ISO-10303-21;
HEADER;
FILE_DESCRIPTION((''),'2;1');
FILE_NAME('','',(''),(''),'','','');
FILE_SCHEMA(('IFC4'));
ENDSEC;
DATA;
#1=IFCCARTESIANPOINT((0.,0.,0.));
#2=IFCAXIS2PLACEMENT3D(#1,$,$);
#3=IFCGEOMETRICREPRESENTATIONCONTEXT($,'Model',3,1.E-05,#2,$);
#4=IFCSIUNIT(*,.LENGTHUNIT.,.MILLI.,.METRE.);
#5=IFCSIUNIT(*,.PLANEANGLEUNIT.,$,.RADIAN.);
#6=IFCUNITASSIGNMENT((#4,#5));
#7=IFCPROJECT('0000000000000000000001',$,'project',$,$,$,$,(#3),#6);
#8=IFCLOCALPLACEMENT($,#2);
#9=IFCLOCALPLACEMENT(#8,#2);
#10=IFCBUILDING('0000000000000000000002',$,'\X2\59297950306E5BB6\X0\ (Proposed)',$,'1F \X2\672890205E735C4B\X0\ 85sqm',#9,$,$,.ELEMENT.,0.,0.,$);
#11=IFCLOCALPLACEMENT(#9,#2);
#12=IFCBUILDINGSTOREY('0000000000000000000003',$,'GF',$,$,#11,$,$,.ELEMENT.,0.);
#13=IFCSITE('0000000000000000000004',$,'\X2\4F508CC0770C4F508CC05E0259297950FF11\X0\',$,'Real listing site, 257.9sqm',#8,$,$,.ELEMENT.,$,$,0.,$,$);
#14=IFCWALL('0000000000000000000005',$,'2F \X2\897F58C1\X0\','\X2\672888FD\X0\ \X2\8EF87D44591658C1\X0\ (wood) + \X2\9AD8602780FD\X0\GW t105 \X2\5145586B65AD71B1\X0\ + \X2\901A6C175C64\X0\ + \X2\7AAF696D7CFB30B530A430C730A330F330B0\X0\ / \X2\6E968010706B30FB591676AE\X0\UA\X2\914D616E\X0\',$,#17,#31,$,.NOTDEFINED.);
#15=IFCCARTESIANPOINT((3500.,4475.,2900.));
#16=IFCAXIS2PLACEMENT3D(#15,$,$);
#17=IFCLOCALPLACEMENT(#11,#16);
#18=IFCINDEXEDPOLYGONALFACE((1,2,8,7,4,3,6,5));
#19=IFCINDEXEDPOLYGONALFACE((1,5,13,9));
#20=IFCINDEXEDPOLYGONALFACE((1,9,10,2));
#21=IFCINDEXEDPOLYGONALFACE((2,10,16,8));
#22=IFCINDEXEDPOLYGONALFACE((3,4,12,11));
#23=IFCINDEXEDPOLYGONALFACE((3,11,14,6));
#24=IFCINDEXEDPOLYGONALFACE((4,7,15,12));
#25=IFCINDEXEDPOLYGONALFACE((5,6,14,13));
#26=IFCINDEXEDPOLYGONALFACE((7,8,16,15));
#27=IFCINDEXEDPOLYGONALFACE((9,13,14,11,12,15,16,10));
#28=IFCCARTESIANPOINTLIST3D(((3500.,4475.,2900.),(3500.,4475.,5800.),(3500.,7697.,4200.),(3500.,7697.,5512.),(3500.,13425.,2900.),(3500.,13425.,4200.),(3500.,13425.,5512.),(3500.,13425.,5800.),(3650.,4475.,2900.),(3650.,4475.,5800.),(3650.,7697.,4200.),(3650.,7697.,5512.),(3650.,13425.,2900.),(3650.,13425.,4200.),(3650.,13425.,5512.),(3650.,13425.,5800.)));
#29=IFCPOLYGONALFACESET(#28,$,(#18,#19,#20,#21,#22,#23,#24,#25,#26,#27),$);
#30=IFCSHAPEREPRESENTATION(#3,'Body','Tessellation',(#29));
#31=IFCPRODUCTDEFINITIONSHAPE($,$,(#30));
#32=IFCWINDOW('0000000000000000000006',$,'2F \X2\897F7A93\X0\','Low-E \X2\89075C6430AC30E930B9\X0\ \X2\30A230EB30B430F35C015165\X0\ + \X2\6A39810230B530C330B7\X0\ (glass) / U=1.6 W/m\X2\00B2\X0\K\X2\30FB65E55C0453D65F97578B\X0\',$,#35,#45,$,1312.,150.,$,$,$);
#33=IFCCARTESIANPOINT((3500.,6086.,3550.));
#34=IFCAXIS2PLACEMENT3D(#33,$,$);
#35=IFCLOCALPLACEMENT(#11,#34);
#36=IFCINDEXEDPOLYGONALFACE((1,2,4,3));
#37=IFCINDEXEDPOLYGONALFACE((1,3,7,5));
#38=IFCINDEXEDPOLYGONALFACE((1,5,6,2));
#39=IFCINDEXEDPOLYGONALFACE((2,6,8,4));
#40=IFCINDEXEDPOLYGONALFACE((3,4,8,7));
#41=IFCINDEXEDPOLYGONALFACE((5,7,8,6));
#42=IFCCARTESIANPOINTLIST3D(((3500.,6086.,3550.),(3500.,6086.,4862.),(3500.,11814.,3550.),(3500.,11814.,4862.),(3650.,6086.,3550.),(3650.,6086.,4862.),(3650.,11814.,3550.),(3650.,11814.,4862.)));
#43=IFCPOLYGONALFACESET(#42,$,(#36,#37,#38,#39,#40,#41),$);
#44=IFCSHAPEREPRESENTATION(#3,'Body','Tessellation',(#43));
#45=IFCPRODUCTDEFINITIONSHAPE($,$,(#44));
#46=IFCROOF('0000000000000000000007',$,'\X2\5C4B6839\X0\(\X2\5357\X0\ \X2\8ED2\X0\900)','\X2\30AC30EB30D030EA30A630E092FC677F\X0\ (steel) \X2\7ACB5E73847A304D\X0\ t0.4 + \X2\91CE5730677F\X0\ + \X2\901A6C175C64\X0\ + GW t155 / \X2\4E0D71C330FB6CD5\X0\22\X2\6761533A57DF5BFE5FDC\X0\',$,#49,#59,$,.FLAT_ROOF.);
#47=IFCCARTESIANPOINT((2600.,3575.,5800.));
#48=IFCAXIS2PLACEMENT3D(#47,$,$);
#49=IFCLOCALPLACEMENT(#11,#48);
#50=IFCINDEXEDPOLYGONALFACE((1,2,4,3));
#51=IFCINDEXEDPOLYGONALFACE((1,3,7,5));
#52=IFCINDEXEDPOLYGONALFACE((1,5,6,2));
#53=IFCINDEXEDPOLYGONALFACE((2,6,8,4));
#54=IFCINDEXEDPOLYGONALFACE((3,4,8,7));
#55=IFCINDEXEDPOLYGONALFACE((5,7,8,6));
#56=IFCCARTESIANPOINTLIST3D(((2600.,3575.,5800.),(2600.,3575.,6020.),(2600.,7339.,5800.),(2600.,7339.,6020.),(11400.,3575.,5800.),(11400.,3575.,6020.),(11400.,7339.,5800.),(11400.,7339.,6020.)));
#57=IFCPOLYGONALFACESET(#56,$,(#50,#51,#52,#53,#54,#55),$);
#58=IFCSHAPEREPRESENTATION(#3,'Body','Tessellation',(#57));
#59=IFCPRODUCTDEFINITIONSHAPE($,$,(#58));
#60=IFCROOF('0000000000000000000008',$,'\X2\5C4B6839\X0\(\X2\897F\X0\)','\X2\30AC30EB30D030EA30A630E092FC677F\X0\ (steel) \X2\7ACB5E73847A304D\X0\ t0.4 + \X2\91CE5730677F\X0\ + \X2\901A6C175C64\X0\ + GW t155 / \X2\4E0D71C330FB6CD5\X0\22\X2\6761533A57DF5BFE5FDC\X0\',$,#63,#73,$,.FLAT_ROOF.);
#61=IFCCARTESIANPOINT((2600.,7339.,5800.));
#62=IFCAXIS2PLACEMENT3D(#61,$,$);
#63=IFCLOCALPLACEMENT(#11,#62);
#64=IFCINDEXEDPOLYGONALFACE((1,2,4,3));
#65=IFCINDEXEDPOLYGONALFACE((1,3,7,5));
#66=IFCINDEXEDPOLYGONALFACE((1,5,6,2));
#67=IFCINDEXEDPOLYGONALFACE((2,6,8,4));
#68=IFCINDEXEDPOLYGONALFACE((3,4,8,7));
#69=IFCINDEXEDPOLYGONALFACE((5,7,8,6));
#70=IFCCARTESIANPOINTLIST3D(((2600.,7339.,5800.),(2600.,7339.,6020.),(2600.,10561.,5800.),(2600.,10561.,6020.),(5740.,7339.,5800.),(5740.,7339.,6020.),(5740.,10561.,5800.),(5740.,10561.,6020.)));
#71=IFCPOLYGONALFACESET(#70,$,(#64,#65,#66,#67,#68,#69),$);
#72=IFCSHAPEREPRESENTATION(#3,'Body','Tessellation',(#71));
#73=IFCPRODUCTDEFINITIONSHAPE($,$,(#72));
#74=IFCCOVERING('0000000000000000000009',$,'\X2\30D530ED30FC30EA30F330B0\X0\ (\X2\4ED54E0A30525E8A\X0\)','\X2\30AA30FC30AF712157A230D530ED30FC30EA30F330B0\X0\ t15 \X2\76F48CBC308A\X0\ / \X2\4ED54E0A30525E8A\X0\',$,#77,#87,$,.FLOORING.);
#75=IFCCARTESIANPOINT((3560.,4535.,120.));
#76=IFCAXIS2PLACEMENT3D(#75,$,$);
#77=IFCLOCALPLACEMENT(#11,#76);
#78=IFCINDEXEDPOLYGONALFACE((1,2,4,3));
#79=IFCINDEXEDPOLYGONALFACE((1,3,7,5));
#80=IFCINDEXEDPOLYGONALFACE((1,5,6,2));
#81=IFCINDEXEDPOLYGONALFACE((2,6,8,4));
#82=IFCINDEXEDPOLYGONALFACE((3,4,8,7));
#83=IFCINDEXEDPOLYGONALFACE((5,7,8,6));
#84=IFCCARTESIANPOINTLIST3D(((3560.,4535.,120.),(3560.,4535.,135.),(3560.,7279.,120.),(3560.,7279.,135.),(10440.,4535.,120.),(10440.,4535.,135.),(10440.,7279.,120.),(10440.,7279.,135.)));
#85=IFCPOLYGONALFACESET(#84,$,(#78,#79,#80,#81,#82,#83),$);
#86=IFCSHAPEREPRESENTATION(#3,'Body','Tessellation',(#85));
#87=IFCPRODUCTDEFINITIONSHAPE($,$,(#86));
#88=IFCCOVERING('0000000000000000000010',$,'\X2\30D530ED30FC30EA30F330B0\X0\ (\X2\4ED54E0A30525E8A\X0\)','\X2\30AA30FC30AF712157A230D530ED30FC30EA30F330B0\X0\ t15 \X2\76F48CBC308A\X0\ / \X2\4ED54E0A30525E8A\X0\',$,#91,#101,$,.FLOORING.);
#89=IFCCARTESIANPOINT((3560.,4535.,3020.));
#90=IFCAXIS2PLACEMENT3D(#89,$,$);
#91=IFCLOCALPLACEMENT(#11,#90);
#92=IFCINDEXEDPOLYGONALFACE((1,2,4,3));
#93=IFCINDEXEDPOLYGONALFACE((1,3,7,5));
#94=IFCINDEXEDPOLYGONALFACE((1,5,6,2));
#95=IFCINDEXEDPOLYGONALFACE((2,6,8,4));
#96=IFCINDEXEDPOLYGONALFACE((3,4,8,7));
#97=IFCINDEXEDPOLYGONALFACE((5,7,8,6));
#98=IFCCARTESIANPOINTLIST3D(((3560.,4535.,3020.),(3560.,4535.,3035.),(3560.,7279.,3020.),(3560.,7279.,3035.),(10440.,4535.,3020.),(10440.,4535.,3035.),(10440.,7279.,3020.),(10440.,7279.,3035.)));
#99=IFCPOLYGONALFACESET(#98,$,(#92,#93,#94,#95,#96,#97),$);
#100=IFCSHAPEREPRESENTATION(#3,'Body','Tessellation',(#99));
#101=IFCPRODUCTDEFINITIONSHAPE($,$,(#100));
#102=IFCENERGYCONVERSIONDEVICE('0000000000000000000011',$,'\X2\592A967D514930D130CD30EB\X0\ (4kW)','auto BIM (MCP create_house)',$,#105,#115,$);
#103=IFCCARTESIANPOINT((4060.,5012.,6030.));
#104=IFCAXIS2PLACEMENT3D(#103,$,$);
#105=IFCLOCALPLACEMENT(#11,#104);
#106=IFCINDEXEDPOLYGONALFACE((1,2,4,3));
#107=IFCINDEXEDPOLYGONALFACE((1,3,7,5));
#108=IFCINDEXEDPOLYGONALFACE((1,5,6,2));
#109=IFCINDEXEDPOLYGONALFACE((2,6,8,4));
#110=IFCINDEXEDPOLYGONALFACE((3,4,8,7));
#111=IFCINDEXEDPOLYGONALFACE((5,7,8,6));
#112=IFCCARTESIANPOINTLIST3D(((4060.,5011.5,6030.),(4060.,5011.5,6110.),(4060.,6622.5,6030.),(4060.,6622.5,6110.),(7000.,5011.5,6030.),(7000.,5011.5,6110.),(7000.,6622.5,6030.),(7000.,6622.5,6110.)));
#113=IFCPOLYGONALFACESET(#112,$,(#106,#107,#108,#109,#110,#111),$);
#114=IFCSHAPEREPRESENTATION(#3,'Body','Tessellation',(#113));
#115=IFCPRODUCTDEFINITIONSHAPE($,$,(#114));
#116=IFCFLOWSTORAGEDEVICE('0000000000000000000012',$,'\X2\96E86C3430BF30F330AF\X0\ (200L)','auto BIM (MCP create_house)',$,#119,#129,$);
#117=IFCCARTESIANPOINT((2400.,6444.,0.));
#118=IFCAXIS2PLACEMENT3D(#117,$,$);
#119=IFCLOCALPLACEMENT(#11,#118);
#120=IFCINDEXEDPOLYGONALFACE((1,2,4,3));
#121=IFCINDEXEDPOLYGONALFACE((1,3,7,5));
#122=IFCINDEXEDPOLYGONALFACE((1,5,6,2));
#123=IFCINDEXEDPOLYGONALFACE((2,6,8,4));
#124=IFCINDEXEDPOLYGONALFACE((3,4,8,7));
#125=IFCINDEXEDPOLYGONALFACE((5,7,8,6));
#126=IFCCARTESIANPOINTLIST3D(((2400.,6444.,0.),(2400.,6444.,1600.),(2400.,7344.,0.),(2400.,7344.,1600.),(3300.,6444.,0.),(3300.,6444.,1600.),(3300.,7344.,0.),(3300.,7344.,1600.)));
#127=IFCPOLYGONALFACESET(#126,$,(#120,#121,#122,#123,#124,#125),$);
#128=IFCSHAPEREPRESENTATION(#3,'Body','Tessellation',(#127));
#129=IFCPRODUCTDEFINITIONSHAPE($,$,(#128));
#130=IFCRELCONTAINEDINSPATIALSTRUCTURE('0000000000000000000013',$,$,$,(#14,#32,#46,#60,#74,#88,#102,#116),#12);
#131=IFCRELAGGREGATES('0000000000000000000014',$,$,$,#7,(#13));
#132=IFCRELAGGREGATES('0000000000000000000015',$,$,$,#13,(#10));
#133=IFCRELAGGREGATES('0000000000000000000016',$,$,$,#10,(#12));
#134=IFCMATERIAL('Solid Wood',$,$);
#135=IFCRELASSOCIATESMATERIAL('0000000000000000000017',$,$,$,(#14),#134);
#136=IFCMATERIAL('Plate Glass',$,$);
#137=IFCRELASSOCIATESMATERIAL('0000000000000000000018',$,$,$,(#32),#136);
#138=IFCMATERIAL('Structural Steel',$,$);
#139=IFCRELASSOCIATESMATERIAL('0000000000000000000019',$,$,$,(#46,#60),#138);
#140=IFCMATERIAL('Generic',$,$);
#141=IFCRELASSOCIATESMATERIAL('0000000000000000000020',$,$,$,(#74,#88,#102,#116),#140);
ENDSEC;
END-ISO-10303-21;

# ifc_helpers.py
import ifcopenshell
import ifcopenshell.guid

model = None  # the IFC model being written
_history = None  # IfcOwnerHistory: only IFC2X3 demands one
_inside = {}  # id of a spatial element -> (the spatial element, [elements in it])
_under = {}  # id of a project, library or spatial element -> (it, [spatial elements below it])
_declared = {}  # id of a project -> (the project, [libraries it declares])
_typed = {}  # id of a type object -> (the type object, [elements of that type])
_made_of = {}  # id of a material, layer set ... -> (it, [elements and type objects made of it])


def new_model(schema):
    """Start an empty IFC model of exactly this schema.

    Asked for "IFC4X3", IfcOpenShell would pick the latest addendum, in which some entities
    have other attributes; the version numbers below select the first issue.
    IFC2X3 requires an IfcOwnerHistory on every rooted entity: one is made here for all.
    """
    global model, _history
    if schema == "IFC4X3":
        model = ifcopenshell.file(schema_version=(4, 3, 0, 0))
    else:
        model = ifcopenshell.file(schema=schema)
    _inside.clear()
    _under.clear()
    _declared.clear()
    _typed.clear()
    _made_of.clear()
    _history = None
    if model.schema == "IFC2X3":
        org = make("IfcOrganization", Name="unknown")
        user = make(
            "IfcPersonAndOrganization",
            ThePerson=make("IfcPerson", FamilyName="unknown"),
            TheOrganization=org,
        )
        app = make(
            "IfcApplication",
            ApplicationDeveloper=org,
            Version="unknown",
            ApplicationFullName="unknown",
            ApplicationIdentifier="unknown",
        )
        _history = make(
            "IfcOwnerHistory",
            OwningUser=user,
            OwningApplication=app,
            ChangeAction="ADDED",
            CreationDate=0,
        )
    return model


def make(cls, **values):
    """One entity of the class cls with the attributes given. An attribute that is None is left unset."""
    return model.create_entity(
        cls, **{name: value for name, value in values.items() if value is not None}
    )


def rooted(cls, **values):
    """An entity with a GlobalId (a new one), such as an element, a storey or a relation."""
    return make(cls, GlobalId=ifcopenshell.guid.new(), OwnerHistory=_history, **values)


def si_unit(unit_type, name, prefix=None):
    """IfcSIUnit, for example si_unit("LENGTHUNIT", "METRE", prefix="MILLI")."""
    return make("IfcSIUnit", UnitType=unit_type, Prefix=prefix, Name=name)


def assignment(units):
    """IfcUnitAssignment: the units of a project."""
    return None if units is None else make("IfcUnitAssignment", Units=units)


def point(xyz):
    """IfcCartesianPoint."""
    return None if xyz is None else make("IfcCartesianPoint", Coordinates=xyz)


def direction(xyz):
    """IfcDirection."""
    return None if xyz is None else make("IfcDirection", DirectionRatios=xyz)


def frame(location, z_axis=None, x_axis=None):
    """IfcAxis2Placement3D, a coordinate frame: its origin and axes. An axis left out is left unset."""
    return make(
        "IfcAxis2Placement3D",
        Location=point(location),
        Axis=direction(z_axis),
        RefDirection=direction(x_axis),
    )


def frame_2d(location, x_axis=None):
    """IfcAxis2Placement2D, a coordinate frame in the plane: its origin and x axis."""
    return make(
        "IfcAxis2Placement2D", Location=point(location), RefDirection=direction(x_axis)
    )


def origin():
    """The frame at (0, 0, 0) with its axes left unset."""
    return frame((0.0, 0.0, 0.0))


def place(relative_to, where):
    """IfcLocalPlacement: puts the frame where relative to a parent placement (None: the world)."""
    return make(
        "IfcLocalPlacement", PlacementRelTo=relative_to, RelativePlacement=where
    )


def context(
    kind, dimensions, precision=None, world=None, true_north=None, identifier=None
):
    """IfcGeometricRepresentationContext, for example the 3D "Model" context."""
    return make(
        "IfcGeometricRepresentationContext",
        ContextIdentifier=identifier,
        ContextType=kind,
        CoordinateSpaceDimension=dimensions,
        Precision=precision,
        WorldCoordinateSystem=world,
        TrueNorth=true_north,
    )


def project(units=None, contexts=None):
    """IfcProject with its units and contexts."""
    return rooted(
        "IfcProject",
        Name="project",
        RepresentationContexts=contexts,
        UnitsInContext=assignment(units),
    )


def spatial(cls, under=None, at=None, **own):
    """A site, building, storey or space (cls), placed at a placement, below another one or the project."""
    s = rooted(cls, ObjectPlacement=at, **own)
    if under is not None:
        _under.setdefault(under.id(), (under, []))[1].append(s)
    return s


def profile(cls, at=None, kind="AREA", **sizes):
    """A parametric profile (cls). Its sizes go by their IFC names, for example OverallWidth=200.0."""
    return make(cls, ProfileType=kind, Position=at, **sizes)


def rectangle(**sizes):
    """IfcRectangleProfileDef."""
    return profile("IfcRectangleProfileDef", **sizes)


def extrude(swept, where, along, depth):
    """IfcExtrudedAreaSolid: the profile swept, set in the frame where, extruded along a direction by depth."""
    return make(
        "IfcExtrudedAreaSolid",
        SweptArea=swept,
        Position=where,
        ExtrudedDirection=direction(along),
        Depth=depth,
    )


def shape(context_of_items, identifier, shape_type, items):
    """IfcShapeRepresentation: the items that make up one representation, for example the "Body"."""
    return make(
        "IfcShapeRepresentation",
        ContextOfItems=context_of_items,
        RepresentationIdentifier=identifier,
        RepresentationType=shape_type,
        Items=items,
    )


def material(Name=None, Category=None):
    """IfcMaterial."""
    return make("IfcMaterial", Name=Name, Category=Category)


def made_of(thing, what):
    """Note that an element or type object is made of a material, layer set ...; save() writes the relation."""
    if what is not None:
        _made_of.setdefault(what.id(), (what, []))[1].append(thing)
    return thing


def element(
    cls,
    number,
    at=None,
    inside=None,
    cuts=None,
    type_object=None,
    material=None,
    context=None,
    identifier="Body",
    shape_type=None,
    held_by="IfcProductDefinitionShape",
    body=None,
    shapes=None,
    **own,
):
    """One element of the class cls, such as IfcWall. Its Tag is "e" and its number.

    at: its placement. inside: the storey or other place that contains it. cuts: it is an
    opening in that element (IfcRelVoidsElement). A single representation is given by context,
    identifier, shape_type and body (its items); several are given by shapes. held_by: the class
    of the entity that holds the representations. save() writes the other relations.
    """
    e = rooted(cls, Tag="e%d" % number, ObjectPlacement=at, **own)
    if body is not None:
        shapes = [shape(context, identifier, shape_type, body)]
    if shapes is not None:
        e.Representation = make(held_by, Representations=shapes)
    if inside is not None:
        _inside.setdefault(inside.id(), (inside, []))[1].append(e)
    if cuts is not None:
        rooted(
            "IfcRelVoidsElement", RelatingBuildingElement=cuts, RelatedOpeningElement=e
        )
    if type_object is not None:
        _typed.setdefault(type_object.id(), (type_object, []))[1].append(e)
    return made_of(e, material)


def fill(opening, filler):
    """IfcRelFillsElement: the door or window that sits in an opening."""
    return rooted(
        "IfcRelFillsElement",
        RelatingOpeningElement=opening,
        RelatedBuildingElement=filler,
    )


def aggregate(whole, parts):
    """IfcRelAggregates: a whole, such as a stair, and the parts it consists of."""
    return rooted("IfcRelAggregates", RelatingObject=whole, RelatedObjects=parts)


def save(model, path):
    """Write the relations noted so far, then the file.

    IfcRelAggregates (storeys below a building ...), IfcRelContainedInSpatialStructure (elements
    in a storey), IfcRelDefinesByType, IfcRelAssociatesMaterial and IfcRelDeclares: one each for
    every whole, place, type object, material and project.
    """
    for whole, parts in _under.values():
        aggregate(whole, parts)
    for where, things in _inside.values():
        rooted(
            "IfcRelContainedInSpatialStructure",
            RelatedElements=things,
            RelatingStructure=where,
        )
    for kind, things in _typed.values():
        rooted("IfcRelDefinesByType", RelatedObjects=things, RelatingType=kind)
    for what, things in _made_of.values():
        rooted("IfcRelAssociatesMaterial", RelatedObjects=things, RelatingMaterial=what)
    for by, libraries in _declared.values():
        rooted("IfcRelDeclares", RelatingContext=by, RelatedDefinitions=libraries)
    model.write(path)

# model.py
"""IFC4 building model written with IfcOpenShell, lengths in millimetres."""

from ifc_helpers import new_model, si_unit, frame, frame_2d, origin, place, context, project, spatial, rectangle, extrude, material, element, fill, save


model = new_model("IFC4")

# Units and contexts
model_context = context("Model", 3, precision=1e-05, world=origin())
ifc_project = project(units=[si_unit("LENGTHUNIT", "METRE", prefix="MILLI"), si_unit("PLANEANGLEUNIT", "RADIAN")], contexts=[model_context])

# Site, building, storey
site_placement = place(None, origin())
site = spatial("IfcSite", under=ifc_project, at=site_placement, Name="佐賀県佐賀市天祐１", ObjectType="Real listing site, 257.9sqm", CompositionType="ELEMENT", RefElevation=0.0)
building_placement = place(site_placement, origin())
building = spatial("IfcBuilding", under=site, at=building_placement, Name="天祐の家 (Proposed)", ObjectType="1F 木造平屋 85sqm", CompositionType="ELEMENT", ElevationOfRefHeight=0.0, ElevationOfTerrain=0.0)
storey_placement = place(building_placement, origin())
storey = spatial("IfcBuildingStorey", under=building, at=storey_placement, Name="GF", CompositionType="ELEMENT", Elevation=0.0)

# Shared definitions
ifc_material_1 = material(Name="Solid Wood")
ifc_material_2 = material(Name="Generic")

# Shared definitions
ifc_material_3 = material(Name="Plate Glass")

# Wall, opening, window
wall_1_placement = place(storey_placement, frame((3500.0, 4475.0, 2900.0)))
wall_1 = element("IfcWall", 1, at=wall_1_placement, inside=storey, material=ifc_material_1, Name="2F 西壁", Description="木製 軸組外壁 (wood) + 高性能GW t105 充填断熱 + 通気層 + 窯業系サイディング / 準耐火・外皮UA配慮", PredefinedType="NOTDEFINED", context=model_context, shape_type="SweptSolid", body=[
    extrude(rectangle(XDim=150.0, YDim=8950.0, at=frame_2d((75.0, 4475.0))), frame((3500.0, 4475.0, 2900.0)), (0.0, 0.0, 1.0), 2900.0),
])
opening_1_placement = place(storey_placement, frame((3500.0, 6086.0, 3550.0)))
opening_1 = element("IfcOpeningElement", 2, at=opening_1_placement, cuts=wall_1, PredefinedType="NOTDEFINED", context=model_context, shape_type="SweptSolid", body=[
    extrude(rectangle(XDim=150.0, YDim=5728.0, at=frame_2d((75.0, 2864.0))), frame((3500.0, 6086.0, 3550.0)), (0.0, 0.0, 1.0), 1312.0),
])
window_1_placement = place(storey_placement, frame((3500.0, 6086.0, 3550.0)))
window_1 = element("IfcWindow", 3, at=window_1_placement, inside=storey, material=ifc_material_3, Name="2F 西窓", Description="Low-E 複層ガラス アルゴン封入 + 樹脂サッシ (glass) / U=1.6 W/m²K・日射取得型", OverallHeight=1312.0, OverallWidth=150.0, context=model_context, shape_type="SweptSolid", body=[
    extrude(rectangle(XDim=150.0, YDim=5728.0, at=frame_2d((75.0, 2864.0))), frame((3500.0, 6086.0, 3550.0)), (0.0, 0.0, 1.0), 1312.0),
])
fill(opening_1, window_1)

# Roofs
ifc_material_4 = material(Name="Structural Steel")
roof_1_placement = place(storey_placement, frame((2600.0, 3575.0, 5800.0)))
element("IfcRoof", 4, at=roof_1_placement, inside=storey, material=ifc_material_4, Name="屋根(南 軒900)", Description="ガルバリウム鋼板 (steel) 立平葺き t0.4 + 野地板 + 通気層 + GW t155 / 不燃・法22条区域対応", PredefinedType="FLAT_ROOF", context=model_context, shape_type="SweptSolid", body=[
    extrude(rectangle(XDim=8800.0, YDim=3764.0, at=frame_2d((4400.0, 1882.0))), frame((2600.0, 3575.0, 5800.0)), (0.0, 0.0, 1.0), 220.0),
])
roof_2_placement = place(storey_placement, frame((2600.0, 7339.0, 5800.0)))
element("IfcRoof", 5, at=roof_2_placement, inside=storey, material=ifc_material_4, Name="屋根(西)", Description="ガルバリウム鋼板 (steel) 立平葺き t0.4 + 野地板 + 通気層 + GW t155 / 不燃・法22条区域対応", PredefinedType="FLAT_ROOF", context=model_context, shape_type="SweptSolid", body=[
    extrude(rectangle(XDim=3140.0, YDim=3222.0, at=frame_2d((1570.0, 1611.0))), frame((2600.0, 7339.0, 5800.0)), (0.0, 0.0, 1.0), 220.0),
])

# Coverings
covering_1_placement = place(storey_placement, frame((3560.0, 4535.0, 120.0)))
element("IfcCovering", 6, at=covering_1_placement, inside=storey, material=ifc_material_2, Name="フローリング (仕上げ床)", Description="オーク無垢フローリング t15 直貼り / 仕上げ床", PredefinedType="FLOORING", context=model_context, shape_type="SweptSolid", body=[
    extrude(rectangle(XDim=6880.0, YDim=2744.0, at=frame_2d((3440.0, 1372.0))), frame((3560.0, 4535.0, 120.0)), (0.0, 0.0, 1.0), 15.0),
])
covering_2_placement = place(storey_placement, frame((3560.0, 4535.0, 3020.0)))
element("IfcCovering", 7, at=covering_2_placement, inside=storey, material=ifc_material_2, Name="フローリング (仕上げ床)", Description="オーク無垢フローリング t15 直貼り / 仕上げ床", PredefinedType="FLOORING", context=model_context, shape_type="SweptSolid", body=[
    extrude(rectangle(XDim=6880.0, YDim=2744.0, at=frame_2d((3440.0, 1372.0))), frame((3560.0, 4535.0, 3020.0)), (0.0, 0.0, 1.0), 15.0),
])

# Energy conversion device
energy_conversion_device_placement = place(storey_placement, frame((4060.0, 5012.0, 6030.0)))
element("IfcEnergyConversionDevice", 8, at=energy_conversion_device_placement, inside=storey, material=ifc_material_2, Name="太陽光パネル (4kW)", Description="auto BIM (MCP create_house)", context=model_context, shape_type="SweptSolid", body=[
    extrude(rectangle(XDim=2940.0, YDim=1611.0, at=frame_2d((1470.0, 805.0))), frame((4060.0, 5012.0, 6030.0)), (0.0, 0.0, 1.0), 80.0),
])

# Flow storage device
flow_storage_device_placement = place(storey_placement, frame((2400.0, 6444.0, 0.0)))
element("IfcFlowStorageDevice", 9, at=flow_storage_device_placement, inside=storey, material=ifc_material_2, Name="雨水タンク (200L)", Description="auto BIM (MCP create_house)", context=model_context, shape_type="SweptSolid", body=[
    extrude(rectangle(XDim=900.0, YDim=900.0, at=frame_2d((450.0, 450.0))), frame((2400.0, 6444.0, 0.0)), (0.0, 0.0, 1.0), 1600.0),
])

save(model, "model.ifc")
